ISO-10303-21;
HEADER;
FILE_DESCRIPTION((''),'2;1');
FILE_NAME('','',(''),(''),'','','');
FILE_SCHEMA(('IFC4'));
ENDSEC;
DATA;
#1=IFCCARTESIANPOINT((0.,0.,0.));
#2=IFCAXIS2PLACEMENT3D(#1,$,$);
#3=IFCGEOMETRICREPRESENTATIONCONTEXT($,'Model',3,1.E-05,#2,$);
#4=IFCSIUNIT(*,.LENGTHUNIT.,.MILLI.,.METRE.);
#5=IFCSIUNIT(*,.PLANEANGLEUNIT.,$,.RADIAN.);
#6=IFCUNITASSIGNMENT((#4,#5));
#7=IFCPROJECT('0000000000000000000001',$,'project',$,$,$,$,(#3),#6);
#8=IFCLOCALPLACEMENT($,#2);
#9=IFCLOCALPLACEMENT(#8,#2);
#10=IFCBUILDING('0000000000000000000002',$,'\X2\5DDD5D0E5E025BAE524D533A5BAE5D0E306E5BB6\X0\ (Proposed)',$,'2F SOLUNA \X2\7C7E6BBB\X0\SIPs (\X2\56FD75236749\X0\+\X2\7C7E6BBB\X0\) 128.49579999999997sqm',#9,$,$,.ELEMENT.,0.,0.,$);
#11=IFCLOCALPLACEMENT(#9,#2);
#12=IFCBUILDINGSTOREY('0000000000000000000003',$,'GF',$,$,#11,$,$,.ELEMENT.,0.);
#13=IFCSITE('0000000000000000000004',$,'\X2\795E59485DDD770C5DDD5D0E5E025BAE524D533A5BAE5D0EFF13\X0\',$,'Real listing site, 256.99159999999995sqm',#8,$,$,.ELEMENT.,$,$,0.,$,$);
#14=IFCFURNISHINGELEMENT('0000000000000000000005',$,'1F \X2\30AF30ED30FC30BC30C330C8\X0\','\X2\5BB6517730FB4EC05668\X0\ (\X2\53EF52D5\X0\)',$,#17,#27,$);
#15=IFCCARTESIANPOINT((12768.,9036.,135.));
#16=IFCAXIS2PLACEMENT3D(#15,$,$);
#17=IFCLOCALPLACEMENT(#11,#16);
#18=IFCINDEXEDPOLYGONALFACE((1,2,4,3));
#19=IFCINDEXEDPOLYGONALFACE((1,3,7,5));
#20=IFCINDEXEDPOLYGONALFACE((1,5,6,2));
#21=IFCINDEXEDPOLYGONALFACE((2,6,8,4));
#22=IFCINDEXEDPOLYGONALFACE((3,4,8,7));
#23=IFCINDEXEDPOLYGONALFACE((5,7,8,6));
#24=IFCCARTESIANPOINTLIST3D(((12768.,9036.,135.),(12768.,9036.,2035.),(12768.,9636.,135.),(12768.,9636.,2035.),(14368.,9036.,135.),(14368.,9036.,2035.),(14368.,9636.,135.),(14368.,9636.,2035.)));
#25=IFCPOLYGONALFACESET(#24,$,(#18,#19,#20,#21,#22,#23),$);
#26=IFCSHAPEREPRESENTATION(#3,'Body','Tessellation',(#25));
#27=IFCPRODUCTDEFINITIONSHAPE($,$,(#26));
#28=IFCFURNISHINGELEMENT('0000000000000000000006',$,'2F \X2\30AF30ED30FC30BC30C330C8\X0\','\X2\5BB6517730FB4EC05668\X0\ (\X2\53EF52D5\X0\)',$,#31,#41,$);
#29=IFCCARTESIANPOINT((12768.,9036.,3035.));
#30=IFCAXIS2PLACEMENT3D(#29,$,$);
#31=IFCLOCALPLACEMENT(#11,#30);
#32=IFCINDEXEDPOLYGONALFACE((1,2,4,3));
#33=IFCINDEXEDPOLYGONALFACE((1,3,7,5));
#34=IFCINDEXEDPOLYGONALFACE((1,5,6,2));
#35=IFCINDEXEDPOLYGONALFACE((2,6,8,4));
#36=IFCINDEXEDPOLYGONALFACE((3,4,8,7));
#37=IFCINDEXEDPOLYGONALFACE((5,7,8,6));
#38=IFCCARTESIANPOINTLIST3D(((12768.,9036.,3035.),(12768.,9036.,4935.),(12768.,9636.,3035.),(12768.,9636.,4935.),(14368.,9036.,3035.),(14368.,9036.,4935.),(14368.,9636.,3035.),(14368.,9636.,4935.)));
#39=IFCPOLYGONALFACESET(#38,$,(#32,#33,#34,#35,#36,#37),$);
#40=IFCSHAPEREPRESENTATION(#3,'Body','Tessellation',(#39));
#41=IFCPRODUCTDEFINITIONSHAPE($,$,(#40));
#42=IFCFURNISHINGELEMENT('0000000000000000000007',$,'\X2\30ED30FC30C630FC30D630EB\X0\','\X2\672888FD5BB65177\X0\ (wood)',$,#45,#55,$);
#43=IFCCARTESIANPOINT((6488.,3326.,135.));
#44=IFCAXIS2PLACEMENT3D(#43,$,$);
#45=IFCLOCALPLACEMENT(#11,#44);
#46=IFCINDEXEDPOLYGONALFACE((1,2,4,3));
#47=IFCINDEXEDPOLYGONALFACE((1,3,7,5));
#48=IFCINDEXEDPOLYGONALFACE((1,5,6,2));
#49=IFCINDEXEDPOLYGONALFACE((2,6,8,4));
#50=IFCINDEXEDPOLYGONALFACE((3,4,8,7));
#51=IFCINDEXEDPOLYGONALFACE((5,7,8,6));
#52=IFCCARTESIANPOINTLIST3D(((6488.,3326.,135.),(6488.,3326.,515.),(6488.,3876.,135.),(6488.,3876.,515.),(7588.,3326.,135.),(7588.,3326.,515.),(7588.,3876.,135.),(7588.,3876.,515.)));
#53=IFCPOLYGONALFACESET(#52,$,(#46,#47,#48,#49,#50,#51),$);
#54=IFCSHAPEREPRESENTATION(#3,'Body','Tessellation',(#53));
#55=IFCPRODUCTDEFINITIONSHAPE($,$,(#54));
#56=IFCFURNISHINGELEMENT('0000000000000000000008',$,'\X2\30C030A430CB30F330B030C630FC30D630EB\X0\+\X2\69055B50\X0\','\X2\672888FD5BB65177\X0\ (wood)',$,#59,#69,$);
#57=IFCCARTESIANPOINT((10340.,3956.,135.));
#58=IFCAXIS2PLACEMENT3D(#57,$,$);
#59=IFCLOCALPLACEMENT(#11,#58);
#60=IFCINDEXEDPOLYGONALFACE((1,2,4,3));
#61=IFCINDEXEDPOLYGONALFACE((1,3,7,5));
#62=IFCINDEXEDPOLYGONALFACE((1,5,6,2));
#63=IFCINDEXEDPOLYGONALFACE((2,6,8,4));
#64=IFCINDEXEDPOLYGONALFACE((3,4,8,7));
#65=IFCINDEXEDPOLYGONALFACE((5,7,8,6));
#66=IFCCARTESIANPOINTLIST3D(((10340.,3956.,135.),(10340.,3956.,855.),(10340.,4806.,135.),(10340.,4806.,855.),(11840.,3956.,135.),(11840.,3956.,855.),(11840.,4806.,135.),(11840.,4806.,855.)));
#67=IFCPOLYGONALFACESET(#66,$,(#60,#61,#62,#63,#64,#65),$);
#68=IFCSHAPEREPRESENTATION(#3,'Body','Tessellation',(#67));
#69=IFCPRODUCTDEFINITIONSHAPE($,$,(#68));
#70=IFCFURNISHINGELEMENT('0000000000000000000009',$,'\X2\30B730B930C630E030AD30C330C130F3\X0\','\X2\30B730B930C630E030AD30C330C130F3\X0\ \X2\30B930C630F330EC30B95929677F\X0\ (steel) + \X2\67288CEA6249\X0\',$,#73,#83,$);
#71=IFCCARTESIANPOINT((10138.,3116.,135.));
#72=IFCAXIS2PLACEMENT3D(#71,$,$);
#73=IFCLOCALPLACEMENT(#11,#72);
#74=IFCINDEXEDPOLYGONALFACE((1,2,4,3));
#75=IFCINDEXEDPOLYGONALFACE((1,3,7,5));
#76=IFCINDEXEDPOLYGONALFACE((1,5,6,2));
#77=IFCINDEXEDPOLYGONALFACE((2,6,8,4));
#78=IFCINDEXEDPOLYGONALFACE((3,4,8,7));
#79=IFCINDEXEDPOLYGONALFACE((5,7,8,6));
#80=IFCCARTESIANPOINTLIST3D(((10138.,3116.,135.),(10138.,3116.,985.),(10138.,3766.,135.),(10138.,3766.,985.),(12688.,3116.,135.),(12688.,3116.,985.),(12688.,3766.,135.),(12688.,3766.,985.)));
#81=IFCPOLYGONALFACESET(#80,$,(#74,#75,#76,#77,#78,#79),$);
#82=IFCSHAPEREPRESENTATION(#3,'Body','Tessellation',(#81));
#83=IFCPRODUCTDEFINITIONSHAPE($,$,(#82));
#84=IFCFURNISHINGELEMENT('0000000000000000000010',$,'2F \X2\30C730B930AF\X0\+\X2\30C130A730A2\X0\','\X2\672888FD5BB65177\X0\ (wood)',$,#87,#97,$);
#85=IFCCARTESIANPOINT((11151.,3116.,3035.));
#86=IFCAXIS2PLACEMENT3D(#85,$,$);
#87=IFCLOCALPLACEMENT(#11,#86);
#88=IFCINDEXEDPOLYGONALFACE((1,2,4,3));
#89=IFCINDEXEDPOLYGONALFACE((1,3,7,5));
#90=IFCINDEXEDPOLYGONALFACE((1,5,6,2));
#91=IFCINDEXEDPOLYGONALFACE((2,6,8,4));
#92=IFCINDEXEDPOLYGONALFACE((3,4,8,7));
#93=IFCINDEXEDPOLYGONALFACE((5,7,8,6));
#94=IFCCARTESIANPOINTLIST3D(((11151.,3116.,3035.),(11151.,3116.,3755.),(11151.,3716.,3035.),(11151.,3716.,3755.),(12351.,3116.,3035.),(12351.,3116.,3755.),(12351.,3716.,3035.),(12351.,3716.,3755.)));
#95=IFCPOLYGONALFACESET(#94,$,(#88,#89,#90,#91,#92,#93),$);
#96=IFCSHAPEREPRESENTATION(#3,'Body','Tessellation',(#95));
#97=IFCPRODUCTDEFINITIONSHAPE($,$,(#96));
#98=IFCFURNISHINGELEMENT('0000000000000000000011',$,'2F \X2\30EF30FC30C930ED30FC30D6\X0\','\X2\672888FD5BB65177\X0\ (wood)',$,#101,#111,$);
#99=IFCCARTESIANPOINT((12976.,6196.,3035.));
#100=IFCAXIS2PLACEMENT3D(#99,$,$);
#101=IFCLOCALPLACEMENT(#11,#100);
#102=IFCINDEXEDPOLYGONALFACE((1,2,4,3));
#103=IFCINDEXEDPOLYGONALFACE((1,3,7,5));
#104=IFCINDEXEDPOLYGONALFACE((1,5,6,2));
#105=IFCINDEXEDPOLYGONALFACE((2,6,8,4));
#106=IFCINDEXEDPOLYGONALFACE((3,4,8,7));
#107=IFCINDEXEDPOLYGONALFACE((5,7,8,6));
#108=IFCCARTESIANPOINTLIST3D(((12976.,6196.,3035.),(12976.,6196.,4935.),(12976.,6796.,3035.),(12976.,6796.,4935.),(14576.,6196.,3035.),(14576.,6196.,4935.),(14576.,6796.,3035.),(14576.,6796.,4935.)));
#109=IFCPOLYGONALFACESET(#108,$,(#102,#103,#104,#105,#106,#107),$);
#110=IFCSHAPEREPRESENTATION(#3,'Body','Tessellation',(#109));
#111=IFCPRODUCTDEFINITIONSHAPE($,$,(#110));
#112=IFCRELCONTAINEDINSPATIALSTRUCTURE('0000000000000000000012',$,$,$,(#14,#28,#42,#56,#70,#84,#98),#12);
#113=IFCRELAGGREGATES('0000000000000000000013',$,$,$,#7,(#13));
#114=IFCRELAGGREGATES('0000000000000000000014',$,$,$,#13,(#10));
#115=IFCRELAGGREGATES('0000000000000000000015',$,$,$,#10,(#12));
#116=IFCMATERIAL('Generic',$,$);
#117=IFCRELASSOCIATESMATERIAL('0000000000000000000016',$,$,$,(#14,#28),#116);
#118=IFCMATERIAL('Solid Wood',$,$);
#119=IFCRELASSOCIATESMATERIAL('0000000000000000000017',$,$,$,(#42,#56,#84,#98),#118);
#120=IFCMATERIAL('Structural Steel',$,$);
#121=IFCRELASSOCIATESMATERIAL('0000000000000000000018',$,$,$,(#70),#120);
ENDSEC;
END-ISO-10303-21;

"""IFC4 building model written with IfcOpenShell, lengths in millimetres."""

from ifc_helpers import new_model, si_unit, frame, frame_2d, origin, place, context, project, spatial, rectangle, extrude, material, element, save


model = new_model("IFC4")

# Units and contexts
model_context = context("Model", 3, precision=1e-05, world=origin())
ifc_project = project(units=[si_unit("LENGTHUNIT", "METRE", prefix="MILLI"), si_unit("PLANEANGLEUNIT", "RADIAN")], contexts=[model_context])

# Site, building, storey
site_placement = place(None, origin())
site = spatial("IfcSite", under=ifc_project, at=site_placement, Name="神奈川県川崎市宮前区宮崎３", ObjectType="Real listing site, 256.99159999999995sqm", CompositionType="ELEMENT", RefElevation=0.0)
building_placement = place(site_placement, origin())
building = spatial("IfcBuilding", under=site, at=building_placement, Name="川崎市宮前区宮崎の家 (Proposed)", ObjectType="2F SOLUNA 籾殻SIPs (国産杉+籾殻) 128.49579999999997sqm", CompositionType="ELEMENT", ElevationOfRefHeight=0.0, ElevationOfTerrain=0.0)
storey_placement = place(building_placement, origin())
storey = spatial("IfcBuildingStorey", under=building, at=storey_placement, Name="GF", CompositionType="ELEMENT", Elevation=0.0)

# Shared definitions
ifc_material_1 = material(Name="Solid Wood")

# Shared definitions
ifc_material_2 = material(Name="Generic")

# Furnishing elements
furnishing_1_placement = place(storey_placement, frame((12768.0, 9036.0, 135.0)))
element("IfcFurnishingElement", 1, at=furnishing_1_placement, inside=storey, material=ifc_material_2, Name="1F クローゼット", Description="家具・什器 (可動)", context=model_context, shape_type="SweptSolid", body=[
    extrude(rectangle(XDim=1600.0, YDim=600.0, at=frame_2d((800.0, 300.0))), frame((12768.0, 9036.0, 135.0)), (0.0, 0.0, 1.0), 1900.0),
])
furnishing_2_placement = place(storey_placement, frame((12768.0, 9036.0, 3035.0)))
element("IfcFurnishingElement", 2, at=furnishing_2_placement, inside=storey, material=ifc_material_2, Name="2F クローゼット", Description="家具・什器 (可動)", context=model_context, shape_type="SweptSolid", body=[
    extrude(rectangle(XDim=1600.0, YDim=600.0, at=frame_2d((800.0, 300.0))), frame((12768.0, 9036.0, 3035.0)), (0.0, 0.0, 1.0), 1900.0),
])
furnishing_3_placement = place(storey_placement, frame((6488.0, 3326.0, 135.0)))
element("IfcFurnishingElement", 3, at=furnishing_3_placement, inside=storey, material=ifc_material_1, Name="ローテーブル", Description="木製家具 (wood)", context=model_context, shape_type="SweptSolid", body=[
    extrude(rectangle(XDim=1100.0, YDim=550.0, at=frame_2d((550.0, 275.0))), frame((6488.0, 3326.0, 135.0)), (0.0, 0.0, 1.0), 380.0),
])
furnishing_4_placement = place(storey_placement, frame((10340.0, 3956.0, 135.0)))
element("IfcFurnishingElement", 4, at=furnishing_4_placement, inside=storey, material=ifc_material_1, Name="ダイニングテーブル+椅子", Description="木製家具 (wood)", context=model_context, shape_type="SweptSolid", body=[
    extrude(rectangle(XDim=1500.0, YDim=850.0, at=frame_2d((750.0, 425.0))), frame((10340.0, 3956.0, 135.0)), (0.0, 0.0, 1.0), 720.0),
])
ifc_material_3 = material(Name="Structural Steel")
furnishing_5_placement = place(storey_placement, frame((10138.0, 3116.0, 135.0)))
element("IfcFurnishingElement", 5, at=furnishing_5_placement, inside=storey, material=ifc_material_3, Name="システムキッチン", Description="システムキッチン ステンレス天板 (steel) + 木質扉", context=model_context, shape_type="SweptSolid", body=[
    extrude(rectangle(XDim=2550.0, YDim=650.0, at=frame_2d((1275.0, 325.0))), frame((10138.0, 3116.0, 135.0)), (0.0, 0.0, 1.0), 850.0),
])
furnishing_6_placement = place(storey_placement, frame((11151.0, 3116.0, 3035.0)))
element("IfcFurnishingElement", 6, at=furnishing_6_placement, inside=storey, material=ifc_material_1, Name="2F デスク+チェア", Description="木製家具 (wood)", context=model_context, shape_type="SweptSolid", body=[
    extrude(rectangle(XDim=1200.0, YDim=600.0, at=frame_2d((600.0, 300.0))), frame((11151.0, 3116.0, 3035.0)), (0.0, 0.0, 1.0), 720.0),
])
furnishing_7_placement = place(storey_placement, frame((12976.0, 6196.0, 3035.0)))
element("IfcFurnishingElement", 7, at=furnishing_7_placement, inside=storey, material=ifc_material_1, Name="2F ワードローブ", Description="木製家具 (wood)", context=model_context, shape_type="SweptSolid", body=[
    extrude(rectangle(XDim=1600.0, YDim=600.0, at=frame_2d((800.0, 300.0))), frame((12976.0, 6196.0, 3035.0)), (0.0, 0.0, 1.0), 1900.0),
])

save(model, "model.ifc")
